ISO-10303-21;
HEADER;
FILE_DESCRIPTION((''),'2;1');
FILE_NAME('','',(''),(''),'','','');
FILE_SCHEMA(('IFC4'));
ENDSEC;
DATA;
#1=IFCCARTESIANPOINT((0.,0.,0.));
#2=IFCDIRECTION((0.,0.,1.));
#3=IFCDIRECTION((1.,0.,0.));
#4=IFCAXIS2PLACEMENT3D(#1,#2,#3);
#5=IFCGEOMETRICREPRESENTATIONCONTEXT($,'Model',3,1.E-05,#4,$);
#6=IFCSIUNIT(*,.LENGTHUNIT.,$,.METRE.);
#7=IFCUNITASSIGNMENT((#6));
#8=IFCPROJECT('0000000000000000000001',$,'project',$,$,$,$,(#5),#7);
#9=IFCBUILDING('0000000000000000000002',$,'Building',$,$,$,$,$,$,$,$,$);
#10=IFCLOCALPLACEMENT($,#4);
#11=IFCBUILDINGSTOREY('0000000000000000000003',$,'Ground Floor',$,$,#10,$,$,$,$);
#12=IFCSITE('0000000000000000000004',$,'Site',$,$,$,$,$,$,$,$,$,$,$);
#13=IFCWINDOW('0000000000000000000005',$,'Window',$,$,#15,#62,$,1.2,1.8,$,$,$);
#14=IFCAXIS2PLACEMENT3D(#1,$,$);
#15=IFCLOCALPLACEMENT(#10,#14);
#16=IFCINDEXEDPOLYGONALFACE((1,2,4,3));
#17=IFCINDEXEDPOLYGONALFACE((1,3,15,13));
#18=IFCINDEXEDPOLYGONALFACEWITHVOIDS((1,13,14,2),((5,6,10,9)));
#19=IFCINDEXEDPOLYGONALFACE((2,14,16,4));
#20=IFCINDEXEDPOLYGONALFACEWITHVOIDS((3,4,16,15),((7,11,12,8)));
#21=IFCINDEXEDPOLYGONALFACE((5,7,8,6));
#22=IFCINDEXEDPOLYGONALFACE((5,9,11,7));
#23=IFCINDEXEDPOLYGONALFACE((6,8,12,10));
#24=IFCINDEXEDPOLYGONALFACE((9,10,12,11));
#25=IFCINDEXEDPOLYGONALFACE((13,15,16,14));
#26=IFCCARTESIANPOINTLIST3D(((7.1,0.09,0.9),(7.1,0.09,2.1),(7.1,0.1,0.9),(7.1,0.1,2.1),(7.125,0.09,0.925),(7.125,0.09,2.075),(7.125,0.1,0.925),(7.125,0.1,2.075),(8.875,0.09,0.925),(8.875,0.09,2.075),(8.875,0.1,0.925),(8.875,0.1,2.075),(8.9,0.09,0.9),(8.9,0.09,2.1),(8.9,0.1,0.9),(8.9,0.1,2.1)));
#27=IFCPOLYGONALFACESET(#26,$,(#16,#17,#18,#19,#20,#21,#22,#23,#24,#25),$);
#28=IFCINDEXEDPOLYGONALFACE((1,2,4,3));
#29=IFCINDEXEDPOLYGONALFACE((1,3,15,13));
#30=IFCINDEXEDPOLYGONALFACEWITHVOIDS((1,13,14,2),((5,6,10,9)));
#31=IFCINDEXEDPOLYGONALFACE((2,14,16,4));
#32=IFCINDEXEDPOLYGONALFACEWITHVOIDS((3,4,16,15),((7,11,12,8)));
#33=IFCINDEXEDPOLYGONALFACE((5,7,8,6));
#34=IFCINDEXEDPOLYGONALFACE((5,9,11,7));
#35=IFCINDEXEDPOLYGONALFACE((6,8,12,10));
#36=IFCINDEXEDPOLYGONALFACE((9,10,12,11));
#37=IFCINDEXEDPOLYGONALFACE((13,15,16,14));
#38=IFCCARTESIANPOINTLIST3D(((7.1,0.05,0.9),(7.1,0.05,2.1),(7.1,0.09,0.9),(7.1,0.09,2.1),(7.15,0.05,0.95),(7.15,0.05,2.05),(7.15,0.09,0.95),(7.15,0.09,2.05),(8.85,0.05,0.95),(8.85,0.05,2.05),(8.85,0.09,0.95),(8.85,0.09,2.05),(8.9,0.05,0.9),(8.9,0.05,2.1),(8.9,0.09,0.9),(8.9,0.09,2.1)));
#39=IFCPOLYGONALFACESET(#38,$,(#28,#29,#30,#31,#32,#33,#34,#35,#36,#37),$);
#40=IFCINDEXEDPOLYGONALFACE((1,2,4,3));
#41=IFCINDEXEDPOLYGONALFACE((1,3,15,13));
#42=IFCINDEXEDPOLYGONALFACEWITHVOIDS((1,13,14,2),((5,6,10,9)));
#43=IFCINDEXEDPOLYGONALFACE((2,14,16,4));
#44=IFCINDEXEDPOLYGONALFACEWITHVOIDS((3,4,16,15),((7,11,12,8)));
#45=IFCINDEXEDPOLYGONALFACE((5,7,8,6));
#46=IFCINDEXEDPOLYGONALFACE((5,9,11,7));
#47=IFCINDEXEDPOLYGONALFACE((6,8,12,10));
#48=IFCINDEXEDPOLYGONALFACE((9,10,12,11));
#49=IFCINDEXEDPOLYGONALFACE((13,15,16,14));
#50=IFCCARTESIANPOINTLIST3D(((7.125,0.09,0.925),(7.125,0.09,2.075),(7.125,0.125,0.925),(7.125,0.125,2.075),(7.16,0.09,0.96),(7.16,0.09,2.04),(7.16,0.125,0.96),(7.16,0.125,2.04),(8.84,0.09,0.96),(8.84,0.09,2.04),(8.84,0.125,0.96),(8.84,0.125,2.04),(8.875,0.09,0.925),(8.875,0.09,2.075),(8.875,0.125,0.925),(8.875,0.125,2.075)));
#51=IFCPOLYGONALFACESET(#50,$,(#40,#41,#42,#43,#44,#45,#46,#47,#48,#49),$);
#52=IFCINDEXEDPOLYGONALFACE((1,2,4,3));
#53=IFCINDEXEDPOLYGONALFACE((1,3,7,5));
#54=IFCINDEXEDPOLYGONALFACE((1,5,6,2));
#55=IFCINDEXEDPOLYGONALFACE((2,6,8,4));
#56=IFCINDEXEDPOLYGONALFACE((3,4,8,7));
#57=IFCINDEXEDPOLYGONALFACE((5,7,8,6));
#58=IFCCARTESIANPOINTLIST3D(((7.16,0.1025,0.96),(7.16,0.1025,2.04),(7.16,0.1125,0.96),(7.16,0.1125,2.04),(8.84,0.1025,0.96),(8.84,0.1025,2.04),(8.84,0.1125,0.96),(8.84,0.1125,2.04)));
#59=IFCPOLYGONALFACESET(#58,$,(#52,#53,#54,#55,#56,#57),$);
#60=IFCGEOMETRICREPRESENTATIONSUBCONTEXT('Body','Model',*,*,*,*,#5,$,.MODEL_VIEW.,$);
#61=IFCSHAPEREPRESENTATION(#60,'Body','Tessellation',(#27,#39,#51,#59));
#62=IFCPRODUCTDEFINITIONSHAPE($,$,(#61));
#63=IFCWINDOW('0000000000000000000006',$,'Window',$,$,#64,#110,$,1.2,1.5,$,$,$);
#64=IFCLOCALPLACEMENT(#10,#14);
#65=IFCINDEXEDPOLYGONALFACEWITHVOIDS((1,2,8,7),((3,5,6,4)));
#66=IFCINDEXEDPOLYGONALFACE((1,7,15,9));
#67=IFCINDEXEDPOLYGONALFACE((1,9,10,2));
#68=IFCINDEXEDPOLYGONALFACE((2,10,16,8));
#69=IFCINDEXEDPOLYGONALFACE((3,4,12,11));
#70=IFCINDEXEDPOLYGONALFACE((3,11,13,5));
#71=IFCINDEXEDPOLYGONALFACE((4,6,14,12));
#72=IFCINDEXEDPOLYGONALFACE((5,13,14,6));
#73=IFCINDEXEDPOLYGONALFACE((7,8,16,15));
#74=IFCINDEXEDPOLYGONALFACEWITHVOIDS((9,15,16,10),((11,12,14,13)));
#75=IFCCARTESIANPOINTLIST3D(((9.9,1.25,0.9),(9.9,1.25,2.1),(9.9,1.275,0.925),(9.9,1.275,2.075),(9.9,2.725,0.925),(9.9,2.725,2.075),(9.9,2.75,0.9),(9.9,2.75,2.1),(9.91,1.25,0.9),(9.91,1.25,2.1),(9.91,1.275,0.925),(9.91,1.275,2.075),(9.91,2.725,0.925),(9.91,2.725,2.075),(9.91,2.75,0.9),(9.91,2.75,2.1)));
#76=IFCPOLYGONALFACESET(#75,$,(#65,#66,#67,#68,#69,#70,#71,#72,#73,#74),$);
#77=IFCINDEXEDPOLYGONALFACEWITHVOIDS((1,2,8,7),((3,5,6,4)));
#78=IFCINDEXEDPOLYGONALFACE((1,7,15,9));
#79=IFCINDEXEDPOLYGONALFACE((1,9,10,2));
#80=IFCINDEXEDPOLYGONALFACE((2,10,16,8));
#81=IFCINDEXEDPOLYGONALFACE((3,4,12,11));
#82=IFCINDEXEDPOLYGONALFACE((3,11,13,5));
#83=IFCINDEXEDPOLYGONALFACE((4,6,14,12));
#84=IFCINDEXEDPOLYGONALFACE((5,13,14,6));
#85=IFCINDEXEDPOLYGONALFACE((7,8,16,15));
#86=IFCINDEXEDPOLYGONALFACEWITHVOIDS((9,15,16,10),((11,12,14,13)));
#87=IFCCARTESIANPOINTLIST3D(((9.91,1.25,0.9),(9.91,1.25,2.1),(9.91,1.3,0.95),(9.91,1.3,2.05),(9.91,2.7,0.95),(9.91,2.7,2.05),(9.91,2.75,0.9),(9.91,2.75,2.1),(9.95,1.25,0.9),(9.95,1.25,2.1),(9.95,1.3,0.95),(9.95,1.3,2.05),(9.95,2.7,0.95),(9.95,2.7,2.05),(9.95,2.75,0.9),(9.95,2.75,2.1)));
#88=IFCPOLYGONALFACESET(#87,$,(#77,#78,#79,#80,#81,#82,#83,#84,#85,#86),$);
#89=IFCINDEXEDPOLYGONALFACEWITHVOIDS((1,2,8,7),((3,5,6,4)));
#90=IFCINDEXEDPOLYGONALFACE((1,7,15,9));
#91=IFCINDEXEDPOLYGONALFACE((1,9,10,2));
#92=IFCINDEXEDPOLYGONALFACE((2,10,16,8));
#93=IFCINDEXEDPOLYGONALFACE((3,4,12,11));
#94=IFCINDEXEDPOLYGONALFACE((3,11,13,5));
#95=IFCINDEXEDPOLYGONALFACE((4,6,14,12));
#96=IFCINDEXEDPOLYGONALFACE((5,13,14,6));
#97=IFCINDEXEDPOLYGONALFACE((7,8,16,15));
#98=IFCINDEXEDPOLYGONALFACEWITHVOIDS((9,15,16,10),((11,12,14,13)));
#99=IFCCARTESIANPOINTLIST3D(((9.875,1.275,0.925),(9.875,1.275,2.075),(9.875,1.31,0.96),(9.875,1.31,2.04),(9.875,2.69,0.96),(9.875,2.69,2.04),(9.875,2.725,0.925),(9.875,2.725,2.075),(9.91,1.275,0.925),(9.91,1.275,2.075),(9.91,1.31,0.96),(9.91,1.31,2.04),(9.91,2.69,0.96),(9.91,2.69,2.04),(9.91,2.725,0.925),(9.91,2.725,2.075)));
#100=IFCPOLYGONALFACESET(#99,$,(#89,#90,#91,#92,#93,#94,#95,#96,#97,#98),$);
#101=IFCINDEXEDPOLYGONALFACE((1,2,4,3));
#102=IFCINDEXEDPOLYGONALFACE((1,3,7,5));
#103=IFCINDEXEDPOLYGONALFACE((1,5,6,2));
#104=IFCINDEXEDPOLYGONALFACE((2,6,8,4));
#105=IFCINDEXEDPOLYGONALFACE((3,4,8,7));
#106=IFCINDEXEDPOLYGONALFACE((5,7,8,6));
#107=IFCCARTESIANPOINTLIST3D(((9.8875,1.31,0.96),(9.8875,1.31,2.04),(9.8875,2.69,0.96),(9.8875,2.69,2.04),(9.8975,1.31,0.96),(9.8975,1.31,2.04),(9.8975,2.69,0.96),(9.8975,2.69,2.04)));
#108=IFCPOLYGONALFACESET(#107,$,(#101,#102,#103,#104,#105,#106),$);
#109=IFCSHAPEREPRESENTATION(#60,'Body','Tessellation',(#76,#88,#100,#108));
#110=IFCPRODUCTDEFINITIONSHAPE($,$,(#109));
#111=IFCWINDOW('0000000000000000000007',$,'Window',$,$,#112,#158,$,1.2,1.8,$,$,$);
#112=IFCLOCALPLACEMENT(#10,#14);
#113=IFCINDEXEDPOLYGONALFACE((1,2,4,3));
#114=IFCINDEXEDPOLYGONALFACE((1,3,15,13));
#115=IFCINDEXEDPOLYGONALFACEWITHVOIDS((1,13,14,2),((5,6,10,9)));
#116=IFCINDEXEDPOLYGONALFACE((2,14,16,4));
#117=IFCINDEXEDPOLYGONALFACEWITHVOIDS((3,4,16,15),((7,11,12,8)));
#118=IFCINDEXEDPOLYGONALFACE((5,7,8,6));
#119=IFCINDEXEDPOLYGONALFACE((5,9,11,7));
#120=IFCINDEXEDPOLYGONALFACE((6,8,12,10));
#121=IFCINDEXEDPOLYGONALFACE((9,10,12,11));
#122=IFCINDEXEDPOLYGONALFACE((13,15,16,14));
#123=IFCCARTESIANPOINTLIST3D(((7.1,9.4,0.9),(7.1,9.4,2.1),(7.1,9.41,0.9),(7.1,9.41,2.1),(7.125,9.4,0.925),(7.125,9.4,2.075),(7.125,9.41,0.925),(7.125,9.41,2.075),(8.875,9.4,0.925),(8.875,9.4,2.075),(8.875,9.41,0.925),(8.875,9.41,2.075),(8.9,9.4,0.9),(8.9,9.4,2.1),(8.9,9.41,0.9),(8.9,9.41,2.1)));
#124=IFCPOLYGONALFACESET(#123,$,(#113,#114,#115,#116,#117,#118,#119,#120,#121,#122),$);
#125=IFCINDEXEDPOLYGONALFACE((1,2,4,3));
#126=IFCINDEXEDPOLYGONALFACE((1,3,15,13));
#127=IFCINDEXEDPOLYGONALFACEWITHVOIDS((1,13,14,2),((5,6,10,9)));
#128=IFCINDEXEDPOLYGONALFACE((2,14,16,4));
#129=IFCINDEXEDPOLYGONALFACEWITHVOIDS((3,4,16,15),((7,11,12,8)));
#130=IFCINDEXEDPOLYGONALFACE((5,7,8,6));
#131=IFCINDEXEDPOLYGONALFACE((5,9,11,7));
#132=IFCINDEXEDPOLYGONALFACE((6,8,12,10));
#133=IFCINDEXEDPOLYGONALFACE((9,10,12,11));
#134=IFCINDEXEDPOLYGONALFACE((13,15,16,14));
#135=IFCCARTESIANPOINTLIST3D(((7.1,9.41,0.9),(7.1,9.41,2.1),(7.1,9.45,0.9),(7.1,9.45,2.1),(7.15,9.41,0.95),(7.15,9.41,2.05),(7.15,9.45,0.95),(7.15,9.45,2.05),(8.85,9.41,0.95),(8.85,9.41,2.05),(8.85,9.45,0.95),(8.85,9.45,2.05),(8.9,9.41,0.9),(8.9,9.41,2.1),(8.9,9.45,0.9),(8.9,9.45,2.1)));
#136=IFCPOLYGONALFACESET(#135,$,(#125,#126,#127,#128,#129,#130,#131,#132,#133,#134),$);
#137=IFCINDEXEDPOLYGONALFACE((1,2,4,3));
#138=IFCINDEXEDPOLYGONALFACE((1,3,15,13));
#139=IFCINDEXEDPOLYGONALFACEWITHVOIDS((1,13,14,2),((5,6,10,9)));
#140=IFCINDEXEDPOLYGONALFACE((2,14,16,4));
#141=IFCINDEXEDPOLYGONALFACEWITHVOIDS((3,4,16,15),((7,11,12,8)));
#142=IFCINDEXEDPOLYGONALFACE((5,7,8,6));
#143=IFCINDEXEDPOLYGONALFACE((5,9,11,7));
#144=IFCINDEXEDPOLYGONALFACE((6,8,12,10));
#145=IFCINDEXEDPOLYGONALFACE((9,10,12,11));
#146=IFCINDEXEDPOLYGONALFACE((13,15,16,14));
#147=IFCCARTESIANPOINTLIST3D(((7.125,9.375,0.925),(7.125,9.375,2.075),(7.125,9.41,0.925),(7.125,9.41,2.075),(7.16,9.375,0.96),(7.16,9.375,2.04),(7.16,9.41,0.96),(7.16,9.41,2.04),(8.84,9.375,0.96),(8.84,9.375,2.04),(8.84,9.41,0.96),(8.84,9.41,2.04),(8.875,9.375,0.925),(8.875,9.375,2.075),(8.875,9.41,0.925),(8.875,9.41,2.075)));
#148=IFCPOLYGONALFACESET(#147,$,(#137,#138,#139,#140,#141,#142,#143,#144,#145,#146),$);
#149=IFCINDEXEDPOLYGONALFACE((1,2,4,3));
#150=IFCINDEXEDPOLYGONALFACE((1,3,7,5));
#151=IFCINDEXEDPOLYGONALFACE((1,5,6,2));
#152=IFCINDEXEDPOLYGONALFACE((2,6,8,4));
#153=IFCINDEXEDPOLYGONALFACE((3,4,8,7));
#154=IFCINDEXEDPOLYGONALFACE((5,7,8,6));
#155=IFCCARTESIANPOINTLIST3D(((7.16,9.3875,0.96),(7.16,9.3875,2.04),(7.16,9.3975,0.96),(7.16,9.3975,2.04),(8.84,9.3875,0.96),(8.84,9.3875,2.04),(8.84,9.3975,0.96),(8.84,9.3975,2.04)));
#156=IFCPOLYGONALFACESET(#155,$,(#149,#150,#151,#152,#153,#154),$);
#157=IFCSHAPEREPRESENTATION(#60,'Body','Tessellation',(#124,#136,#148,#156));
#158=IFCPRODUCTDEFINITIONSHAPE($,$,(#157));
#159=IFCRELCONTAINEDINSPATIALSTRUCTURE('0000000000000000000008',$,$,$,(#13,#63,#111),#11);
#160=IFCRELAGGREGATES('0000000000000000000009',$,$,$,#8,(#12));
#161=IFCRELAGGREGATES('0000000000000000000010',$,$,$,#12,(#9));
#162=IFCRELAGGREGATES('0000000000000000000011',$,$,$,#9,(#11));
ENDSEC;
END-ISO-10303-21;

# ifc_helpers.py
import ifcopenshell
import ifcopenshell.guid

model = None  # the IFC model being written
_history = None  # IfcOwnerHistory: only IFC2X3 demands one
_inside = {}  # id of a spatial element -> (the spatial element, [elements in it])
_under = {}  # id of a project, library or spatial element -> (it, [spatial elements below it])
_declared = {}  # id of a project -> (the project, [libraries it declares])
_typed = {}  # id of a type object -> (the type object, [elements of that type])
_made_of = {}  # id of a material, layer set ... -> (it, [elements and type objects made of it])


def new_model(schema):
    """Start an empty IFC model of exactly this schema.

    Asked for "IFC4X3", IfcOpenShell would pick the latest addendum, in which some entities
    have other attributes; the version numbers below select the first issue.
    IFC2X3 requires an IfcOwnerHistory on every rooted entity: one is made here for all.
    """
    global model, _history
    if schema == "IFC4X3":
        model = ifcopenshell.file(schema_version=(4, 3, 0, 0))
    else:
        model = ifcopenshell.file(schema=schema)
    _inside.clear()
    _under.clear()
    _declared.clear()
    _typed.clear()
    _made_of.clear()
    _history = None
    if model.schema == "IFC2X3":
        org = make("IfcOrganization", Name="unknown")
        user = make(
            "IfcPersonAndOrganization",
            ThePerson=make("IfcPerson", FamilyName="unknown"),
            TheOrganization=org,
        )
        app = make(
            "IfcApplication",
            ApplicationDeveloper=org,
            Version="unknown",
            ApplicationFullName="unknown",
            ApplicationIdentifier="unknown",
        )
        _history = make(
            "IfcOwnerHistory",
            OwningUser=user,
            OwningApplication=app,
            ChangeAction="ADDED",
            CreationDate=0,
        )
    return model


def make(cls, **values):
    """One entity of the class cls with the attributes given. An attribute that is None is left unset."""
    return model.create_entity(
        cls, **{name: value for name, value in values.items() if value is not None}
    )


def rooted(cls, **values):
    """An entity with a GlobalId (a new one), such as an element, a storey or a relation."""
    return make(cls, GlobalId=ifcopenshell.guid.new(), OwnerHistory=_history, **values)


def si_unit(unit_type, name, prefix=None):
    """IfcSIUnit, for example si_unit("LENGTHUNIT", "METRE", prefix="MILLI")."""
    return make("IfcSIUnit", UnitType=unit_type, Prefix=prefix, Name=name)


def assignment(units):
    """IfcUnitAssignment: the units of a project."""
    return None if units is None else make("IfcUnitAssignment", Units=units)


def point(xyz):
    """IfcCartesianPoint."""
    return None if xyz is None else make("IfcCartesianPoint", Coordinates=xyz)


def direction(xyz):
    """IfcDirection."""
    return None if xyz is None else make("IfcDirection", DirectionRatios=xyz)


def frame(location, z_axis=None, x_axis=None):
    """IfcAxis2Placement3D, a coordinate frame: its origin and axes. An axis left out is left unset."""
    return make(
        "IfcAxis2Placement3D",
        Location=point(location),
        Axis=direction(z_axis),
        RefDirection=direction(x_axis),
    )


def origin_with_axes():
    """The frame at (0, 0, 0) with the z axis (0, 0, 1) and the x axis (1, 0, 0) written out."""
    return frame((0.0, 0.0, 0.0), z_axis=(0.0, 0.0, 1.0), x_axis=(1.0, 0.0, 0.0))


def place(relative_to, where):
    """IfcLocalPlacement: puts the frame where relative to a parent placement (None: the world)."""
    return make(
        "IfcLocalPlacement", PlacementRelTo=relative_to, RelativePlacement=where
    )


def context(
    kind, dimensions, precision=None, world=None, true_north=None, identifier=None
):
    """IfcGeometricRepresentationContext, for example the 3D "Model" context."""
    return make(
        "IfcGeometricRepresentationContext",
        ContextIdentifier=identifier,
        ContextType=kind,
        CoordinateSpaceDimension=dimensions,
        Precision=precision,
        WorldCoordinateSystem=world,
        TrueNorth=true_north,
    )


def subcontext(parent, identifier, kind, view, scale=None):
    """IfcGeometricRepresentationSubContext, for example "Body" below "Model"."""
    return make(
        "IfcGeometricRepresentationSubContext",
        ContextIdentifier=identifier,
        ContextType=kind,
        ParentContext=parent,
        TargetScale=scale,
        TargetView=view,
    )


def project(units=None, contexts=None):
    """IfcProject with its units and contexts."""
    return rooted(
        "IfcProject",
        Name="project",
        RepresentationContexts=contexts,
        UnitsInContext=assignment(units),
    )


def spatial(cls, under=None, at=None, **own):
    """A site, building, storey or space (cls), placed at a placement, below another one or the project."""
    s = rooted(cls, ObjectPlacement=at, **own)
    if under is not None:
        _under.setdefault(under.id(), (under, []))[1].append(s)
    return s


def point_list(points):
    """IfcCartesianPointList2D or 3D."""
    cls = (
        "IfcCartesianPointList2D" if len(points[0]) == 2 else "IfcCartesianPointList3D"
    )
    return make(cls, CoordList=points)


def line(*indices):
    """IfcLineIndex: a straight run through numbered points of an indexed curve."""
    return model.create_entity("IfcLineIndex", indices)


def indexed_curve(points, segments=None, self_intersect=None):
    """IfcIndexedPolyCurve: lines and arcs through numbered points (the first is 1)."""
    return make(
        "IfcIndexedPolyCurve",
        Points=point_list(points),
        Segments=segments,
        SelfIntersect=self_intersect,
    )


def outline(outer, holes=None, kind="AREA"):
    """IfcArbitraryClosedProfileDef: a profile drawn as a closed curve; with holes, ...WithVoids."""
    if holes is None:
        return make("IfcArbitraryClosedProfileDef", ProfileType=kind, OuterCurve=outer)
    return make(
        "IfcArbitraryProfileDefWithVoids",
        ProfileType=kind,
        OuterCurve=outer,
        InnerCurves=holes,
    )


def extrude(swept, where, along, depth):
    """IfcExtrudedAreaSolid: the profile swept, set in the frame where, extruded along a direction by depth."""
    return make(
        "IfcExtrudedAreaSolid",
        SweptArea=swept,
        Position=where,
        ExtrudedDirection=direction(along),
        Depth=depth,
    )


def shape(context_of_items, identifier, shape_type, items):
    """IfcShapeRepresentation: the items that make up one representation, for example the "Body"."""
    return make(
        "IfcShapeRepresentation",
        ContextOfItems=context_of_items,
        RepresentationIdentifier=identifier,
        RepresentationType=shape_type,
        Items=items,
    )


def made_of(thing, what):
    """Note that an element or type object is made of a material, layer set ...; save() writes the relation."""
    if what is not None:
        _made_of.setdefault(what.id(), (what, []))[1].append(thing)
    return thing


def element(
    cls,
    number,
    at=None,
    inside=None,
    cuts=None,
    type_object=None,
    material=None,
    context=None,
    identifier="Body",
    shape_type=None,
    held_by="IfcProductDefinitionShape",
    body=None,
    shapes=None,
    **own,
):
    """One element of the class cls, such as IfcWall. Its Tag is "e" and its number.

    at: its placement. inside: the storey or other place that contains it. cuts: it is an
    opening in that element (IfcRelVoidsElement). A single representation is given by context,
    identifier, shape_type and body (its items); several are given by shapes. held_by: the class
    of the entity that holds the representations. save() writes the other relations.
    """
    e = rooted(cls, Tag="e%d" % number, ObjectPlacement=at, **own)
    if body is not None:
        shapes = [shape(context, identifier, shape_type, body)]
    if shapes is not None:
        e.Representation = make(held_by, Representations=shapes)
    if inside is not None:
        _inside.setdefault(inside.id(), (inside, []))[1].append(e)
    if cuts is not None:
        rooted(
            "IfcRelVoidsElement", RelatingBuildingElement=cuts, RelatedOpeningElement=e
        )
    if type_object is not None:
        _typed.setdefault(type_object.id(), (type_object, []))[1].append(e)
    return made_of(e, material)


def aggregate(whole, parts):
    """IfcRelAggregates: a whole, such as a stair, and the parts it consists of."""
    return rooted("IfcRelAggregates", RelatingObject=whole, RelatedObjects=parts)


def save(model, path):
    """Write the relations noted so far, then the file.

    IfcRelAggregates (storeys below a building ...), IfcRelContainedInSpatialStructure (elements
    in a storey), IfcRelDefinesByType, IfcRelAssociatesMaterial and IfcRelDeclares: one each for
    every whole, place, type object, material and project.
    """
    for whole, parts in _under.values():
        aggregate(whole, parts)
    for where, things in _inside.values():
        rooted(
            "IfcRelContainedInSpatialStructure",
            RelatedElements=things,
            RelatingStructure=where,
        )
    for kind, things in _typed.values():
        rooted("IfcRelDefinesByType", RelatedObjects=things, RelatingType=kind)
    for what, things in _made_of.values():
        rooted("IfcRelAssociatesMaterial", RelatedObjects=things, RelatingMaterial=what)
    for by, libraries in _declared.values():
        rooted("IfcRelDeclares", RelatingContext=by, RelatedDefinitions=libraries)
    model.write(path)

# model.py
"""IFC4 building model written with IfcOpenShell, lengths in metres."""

from ifc_helpers import new_model, si_unit, frame, origin_with_axes, place, context, subcontext, project, spatial, line, indexed_curve, outline, extrude, element, save


model = new_model("IFC4")

# Units and contexts
model_context = context("Model", 3, precision=1e-05, world=origin_with_axes())
body_context = subcontext(model_context, "Body", "Model", "MODEL_VIEW")
ifc_project = project(units=[si_unit("LENGTHUNIT", "METRE")], contexts=[model_context])

# Site, building, storey
site = spatial("IfcSite", under=ifc_project, Name="Site")
building = spatial("IfcBuilding", under=site, Name="Building")
storey_placement = place(None, origin_with_axes())
storey = spatial("IfcBuildingStorey", under=building, at=storey_placement, Name="Ground Floor")

# Windows
window_1_placement = place(storey_placement, frame((7.1, 0.0, 0.9), z_axis=(0.0, 0.0, 1.0), x_axis=(1.0, 0.0, 0.0)))
element("IfcWindow", 1, at=window_1_placement, inside=storey, Name="Window", OverallHeight=1.2, OverallWidth=1.8, context=body_context, shape_type="SweptSolid", body=[
    extrude(outline(indexed_curve([(0.0, 0.0), (1.8, 0.0), (1.8, 1.2), (0.0, 1.2)], segments=[line(1, 2, 3, 4, 1)]), holes=[indexed_curve([(0.025, 0.025), (1.775, 0.025), (1.775, 1.175), (0.025, 1.175)], segments=[line(1, 2, 3, 4, 1)])]), frame((0.0, 0.09, 0.0), z_axis=(0.0, -1.0, 0.0), x_axis=(1.0, 0.0, 0.0)), (0.0, 0.0, -1.0), 0.01),
    extrude(outline(indexed_curve([(0.0, 0.0), (1.8, 0.0), (1.8, 1.2), (0.0, 1.2)], segments=[line(1, 2, 3, 4, 1)]), holes=[indexed_curve([(0.05, 0.05), (1.75, 0.05), (1.75, 1.15), (0.05, 1.15)], segments=[line(1, 2, 3, 4, 1)])]), frame((0.0, 0.05, 0.0), z_axis=(0.0, -1.0, 0.0), x_axis=(1.0, 0.0, 0.0)), (0.0, 0.0, -1.0), 0.04),
    extrude(outline(indexed_curve([(0.0, 0.0), (1.75, 0.0), (1.75, 1.15), (0.0, 1.15)], segments=[line(1, 2, 3, 4, 1)]), holes=[indexed_curve([(0.035, 0.035), (1.715, 0.035), (1.715, 1.115), (0.035, 1.115)], segments=[line(1, 2, 3, 4, 1)])]), frame((0.025, 0.09, 0.025), z_axis=(0.0, -1.0, 0.0), x_axis=(1.0, 0.0, 0.0)), (0.0, 0.0, -1.0), 0.035),
    extrude(outline(indexed_curve([(0.035, 0.035), (1.715, 0.035), (1.715, 1.115), (0.035, 1.115)], segments=[line(1, 2, 3, 4, 1)])), frame((0.025, 0.1025, 0.025), z_axis=(0.0, -1.0, 0.0), x_axis=(1.0, 0.0, 0.0)), (0.0, 0.0, -1.0), 0.01),
])
window_2_placement = place(storey_placement, frame((10.0, 1.25, 0.9), z_axis=(0.0, 0.0, 1.0), x_axis=(0.0, 1.0, 0.0)))
element("IfcWindow", 2, at=window_2_placement, inside=storey, Name="Window", OverallHeight=1.2, OverallWidth=1.5, context=body_context, shape_type="SweptSolid", body=[
    extrude(outline(indexed_curve([(0.0, 0.0), (1.5, 0.0), (1.5, 1.2), (0.0, 1.2)], segments=[line(1, 2, 3, 4, 1)]), holes=[indexed_curve([(0.025, 0.025), (1.475, 0.025), (1.475, 1.175), (0.025, 1.175)], segments=[line(1, 2, 3, 4, 1)])]), frame((0.0, 0.09, 0.0), z_axis=(0.0, -1.0, 0.0), x_axis=(1.0, 0.0, 0.0)), (0.0, 0.0, -1.0), 0.01),
    extrude(outline(indexed_curve([(0.0, 0.0), (1.5, 0.0), (1.5, 1.2), (0.0, 1.2)], segments=[line(1, 2, 3, 4, 1)]), holes=[indexed_curve([(0.05, 0.05), (1.45, 0.05), (1.45, 1.15), (0.05, 1.15)], segments=[line(1, 2, 3, 4, 1)])]), frame((0.0, 0.05, 0.0), z_axis=(0.0, -1.0, 0.0), x_axis=(1.0, 0.0, 0.0)), (0.0, 0.0, -1.0), 0.04),
    extrude(outline(indexed_curve([(0.0, 0.0), (1.45, 0.0), (1.45, 1.15), (0.0, 1.15)], segments=[line(1, 2, 3, 4, 1)]), holes=[indexed_curve([(0.035, 0.035), (1.415, 0.035), (1.415, 1.115), (0.035, 1.115)], segments=[line(1, 2, 3, 4, 1)])]), frame((0.025, 0.09, 0.025), z_axis=(0.0, -1.0, 0.0), x_axis=(1.0, 0.0, 0.0)), (0.0, 0.0, -1.0), 0.035),
    extrude(outline(indexed_curve([(0.035, 0.035), (1.415, 0.035), (1.415, 1.115), (0.035, 1.115)], segments=[line(1, 2, 3, 4, 1)])), frame((0.025, 0.1025, 0.025), z_axis=(0.0, -1.0, 0.0), x_axis=(1.0, 0.0, 0.0)), (0.0, 0.0, -1.0), 0.01),
])
window_3_placement = place(storey_placement, frame((8.9, 9.5, 0.9), z_axis=(0.0, 0.0, 1.0), x_axis=(-1.0, 0.0, 0.0)))
element("IfcWindow", 3, at=window_3_placement, inside=storey, Name="Window", OverallHeight=1.2, OverallWidth=1.8, context=body_context, shape_type="SweptSolid", body=[
    extrude(outline(indexed_curve([(0.0, 0.0), (1.8, 0.0), (1.8, 1.2), (0.0, 1.2)], segments=[line(1, 2, 3, 4, 1)]), holes=[indexed_curve([(0.025, 0.025), (1.775, 0.025), (1.775, 1.175), (0.025, 1.175)], segments=[line(1, 2, 3, 4, 1)])]), frame((0.0, 0.09, 0.0), z_axis=(0.0, -1.0, 0.0), x_axis=(1.0, 0.0, 0.0)), (0.0, 0.0, -1.0), 0.01),
    extrude(outline(indexed_curve([(0.0, 0.0), (1.8, 0.0), (1.8, 1.2), (0.0, 1.2)], segments=[line(1, 2, 3, 4, 1)]), holes=[indexed_curve([(0.05, 0.05), (1.75, 0.05), (1.75, 1.15), (0.05, 1.15)], segments=[line(1, 2, 3, 4, 1)])]), frame((0.0, 0.05, 0.0), z_axis=(0.0, -1.0, 0.0), x_axis=(1.0, 0.0, 0.0)), (0.0, 0.0, -1.0), 0.04),
    extrude(outline(indexed_curve([(0.0, 0.0), (1.75, 0.0), (1.75, 1.15), (0.0, 1.15)], segments=[line(1, 2, 3, 4, 1)]), holes=[indexed_curve([(0.035, 0.035), (1.715, 0.035), (1.715, 1.115), (0.035, 1.115)], segments=[line(1, 2, 3, 4, 1)])]), frame((0.025, 0.09, 0.025), z_axis=(0.0, -1.0, 0.0), x_axis=(1.0, 0.0, 0.0)), (0.0, 0.0, -1.0), 0.035),
    extrude(outline(indexed_curve([(0.035, 0.035), (1.715, 0.035), (1.715, 1.115), (0.035, 1.115)], segments=[line(1, 2, 3, 4, 1)])), frame((0.025, 0.1025, 0.025), z_axis=(0.0, -1.0, 0.0), x_axis=(1.0, 0.0, 0.0)), (0.0, 0.0, -1.0), 0.01),
])

save(model, "model.ifc")
